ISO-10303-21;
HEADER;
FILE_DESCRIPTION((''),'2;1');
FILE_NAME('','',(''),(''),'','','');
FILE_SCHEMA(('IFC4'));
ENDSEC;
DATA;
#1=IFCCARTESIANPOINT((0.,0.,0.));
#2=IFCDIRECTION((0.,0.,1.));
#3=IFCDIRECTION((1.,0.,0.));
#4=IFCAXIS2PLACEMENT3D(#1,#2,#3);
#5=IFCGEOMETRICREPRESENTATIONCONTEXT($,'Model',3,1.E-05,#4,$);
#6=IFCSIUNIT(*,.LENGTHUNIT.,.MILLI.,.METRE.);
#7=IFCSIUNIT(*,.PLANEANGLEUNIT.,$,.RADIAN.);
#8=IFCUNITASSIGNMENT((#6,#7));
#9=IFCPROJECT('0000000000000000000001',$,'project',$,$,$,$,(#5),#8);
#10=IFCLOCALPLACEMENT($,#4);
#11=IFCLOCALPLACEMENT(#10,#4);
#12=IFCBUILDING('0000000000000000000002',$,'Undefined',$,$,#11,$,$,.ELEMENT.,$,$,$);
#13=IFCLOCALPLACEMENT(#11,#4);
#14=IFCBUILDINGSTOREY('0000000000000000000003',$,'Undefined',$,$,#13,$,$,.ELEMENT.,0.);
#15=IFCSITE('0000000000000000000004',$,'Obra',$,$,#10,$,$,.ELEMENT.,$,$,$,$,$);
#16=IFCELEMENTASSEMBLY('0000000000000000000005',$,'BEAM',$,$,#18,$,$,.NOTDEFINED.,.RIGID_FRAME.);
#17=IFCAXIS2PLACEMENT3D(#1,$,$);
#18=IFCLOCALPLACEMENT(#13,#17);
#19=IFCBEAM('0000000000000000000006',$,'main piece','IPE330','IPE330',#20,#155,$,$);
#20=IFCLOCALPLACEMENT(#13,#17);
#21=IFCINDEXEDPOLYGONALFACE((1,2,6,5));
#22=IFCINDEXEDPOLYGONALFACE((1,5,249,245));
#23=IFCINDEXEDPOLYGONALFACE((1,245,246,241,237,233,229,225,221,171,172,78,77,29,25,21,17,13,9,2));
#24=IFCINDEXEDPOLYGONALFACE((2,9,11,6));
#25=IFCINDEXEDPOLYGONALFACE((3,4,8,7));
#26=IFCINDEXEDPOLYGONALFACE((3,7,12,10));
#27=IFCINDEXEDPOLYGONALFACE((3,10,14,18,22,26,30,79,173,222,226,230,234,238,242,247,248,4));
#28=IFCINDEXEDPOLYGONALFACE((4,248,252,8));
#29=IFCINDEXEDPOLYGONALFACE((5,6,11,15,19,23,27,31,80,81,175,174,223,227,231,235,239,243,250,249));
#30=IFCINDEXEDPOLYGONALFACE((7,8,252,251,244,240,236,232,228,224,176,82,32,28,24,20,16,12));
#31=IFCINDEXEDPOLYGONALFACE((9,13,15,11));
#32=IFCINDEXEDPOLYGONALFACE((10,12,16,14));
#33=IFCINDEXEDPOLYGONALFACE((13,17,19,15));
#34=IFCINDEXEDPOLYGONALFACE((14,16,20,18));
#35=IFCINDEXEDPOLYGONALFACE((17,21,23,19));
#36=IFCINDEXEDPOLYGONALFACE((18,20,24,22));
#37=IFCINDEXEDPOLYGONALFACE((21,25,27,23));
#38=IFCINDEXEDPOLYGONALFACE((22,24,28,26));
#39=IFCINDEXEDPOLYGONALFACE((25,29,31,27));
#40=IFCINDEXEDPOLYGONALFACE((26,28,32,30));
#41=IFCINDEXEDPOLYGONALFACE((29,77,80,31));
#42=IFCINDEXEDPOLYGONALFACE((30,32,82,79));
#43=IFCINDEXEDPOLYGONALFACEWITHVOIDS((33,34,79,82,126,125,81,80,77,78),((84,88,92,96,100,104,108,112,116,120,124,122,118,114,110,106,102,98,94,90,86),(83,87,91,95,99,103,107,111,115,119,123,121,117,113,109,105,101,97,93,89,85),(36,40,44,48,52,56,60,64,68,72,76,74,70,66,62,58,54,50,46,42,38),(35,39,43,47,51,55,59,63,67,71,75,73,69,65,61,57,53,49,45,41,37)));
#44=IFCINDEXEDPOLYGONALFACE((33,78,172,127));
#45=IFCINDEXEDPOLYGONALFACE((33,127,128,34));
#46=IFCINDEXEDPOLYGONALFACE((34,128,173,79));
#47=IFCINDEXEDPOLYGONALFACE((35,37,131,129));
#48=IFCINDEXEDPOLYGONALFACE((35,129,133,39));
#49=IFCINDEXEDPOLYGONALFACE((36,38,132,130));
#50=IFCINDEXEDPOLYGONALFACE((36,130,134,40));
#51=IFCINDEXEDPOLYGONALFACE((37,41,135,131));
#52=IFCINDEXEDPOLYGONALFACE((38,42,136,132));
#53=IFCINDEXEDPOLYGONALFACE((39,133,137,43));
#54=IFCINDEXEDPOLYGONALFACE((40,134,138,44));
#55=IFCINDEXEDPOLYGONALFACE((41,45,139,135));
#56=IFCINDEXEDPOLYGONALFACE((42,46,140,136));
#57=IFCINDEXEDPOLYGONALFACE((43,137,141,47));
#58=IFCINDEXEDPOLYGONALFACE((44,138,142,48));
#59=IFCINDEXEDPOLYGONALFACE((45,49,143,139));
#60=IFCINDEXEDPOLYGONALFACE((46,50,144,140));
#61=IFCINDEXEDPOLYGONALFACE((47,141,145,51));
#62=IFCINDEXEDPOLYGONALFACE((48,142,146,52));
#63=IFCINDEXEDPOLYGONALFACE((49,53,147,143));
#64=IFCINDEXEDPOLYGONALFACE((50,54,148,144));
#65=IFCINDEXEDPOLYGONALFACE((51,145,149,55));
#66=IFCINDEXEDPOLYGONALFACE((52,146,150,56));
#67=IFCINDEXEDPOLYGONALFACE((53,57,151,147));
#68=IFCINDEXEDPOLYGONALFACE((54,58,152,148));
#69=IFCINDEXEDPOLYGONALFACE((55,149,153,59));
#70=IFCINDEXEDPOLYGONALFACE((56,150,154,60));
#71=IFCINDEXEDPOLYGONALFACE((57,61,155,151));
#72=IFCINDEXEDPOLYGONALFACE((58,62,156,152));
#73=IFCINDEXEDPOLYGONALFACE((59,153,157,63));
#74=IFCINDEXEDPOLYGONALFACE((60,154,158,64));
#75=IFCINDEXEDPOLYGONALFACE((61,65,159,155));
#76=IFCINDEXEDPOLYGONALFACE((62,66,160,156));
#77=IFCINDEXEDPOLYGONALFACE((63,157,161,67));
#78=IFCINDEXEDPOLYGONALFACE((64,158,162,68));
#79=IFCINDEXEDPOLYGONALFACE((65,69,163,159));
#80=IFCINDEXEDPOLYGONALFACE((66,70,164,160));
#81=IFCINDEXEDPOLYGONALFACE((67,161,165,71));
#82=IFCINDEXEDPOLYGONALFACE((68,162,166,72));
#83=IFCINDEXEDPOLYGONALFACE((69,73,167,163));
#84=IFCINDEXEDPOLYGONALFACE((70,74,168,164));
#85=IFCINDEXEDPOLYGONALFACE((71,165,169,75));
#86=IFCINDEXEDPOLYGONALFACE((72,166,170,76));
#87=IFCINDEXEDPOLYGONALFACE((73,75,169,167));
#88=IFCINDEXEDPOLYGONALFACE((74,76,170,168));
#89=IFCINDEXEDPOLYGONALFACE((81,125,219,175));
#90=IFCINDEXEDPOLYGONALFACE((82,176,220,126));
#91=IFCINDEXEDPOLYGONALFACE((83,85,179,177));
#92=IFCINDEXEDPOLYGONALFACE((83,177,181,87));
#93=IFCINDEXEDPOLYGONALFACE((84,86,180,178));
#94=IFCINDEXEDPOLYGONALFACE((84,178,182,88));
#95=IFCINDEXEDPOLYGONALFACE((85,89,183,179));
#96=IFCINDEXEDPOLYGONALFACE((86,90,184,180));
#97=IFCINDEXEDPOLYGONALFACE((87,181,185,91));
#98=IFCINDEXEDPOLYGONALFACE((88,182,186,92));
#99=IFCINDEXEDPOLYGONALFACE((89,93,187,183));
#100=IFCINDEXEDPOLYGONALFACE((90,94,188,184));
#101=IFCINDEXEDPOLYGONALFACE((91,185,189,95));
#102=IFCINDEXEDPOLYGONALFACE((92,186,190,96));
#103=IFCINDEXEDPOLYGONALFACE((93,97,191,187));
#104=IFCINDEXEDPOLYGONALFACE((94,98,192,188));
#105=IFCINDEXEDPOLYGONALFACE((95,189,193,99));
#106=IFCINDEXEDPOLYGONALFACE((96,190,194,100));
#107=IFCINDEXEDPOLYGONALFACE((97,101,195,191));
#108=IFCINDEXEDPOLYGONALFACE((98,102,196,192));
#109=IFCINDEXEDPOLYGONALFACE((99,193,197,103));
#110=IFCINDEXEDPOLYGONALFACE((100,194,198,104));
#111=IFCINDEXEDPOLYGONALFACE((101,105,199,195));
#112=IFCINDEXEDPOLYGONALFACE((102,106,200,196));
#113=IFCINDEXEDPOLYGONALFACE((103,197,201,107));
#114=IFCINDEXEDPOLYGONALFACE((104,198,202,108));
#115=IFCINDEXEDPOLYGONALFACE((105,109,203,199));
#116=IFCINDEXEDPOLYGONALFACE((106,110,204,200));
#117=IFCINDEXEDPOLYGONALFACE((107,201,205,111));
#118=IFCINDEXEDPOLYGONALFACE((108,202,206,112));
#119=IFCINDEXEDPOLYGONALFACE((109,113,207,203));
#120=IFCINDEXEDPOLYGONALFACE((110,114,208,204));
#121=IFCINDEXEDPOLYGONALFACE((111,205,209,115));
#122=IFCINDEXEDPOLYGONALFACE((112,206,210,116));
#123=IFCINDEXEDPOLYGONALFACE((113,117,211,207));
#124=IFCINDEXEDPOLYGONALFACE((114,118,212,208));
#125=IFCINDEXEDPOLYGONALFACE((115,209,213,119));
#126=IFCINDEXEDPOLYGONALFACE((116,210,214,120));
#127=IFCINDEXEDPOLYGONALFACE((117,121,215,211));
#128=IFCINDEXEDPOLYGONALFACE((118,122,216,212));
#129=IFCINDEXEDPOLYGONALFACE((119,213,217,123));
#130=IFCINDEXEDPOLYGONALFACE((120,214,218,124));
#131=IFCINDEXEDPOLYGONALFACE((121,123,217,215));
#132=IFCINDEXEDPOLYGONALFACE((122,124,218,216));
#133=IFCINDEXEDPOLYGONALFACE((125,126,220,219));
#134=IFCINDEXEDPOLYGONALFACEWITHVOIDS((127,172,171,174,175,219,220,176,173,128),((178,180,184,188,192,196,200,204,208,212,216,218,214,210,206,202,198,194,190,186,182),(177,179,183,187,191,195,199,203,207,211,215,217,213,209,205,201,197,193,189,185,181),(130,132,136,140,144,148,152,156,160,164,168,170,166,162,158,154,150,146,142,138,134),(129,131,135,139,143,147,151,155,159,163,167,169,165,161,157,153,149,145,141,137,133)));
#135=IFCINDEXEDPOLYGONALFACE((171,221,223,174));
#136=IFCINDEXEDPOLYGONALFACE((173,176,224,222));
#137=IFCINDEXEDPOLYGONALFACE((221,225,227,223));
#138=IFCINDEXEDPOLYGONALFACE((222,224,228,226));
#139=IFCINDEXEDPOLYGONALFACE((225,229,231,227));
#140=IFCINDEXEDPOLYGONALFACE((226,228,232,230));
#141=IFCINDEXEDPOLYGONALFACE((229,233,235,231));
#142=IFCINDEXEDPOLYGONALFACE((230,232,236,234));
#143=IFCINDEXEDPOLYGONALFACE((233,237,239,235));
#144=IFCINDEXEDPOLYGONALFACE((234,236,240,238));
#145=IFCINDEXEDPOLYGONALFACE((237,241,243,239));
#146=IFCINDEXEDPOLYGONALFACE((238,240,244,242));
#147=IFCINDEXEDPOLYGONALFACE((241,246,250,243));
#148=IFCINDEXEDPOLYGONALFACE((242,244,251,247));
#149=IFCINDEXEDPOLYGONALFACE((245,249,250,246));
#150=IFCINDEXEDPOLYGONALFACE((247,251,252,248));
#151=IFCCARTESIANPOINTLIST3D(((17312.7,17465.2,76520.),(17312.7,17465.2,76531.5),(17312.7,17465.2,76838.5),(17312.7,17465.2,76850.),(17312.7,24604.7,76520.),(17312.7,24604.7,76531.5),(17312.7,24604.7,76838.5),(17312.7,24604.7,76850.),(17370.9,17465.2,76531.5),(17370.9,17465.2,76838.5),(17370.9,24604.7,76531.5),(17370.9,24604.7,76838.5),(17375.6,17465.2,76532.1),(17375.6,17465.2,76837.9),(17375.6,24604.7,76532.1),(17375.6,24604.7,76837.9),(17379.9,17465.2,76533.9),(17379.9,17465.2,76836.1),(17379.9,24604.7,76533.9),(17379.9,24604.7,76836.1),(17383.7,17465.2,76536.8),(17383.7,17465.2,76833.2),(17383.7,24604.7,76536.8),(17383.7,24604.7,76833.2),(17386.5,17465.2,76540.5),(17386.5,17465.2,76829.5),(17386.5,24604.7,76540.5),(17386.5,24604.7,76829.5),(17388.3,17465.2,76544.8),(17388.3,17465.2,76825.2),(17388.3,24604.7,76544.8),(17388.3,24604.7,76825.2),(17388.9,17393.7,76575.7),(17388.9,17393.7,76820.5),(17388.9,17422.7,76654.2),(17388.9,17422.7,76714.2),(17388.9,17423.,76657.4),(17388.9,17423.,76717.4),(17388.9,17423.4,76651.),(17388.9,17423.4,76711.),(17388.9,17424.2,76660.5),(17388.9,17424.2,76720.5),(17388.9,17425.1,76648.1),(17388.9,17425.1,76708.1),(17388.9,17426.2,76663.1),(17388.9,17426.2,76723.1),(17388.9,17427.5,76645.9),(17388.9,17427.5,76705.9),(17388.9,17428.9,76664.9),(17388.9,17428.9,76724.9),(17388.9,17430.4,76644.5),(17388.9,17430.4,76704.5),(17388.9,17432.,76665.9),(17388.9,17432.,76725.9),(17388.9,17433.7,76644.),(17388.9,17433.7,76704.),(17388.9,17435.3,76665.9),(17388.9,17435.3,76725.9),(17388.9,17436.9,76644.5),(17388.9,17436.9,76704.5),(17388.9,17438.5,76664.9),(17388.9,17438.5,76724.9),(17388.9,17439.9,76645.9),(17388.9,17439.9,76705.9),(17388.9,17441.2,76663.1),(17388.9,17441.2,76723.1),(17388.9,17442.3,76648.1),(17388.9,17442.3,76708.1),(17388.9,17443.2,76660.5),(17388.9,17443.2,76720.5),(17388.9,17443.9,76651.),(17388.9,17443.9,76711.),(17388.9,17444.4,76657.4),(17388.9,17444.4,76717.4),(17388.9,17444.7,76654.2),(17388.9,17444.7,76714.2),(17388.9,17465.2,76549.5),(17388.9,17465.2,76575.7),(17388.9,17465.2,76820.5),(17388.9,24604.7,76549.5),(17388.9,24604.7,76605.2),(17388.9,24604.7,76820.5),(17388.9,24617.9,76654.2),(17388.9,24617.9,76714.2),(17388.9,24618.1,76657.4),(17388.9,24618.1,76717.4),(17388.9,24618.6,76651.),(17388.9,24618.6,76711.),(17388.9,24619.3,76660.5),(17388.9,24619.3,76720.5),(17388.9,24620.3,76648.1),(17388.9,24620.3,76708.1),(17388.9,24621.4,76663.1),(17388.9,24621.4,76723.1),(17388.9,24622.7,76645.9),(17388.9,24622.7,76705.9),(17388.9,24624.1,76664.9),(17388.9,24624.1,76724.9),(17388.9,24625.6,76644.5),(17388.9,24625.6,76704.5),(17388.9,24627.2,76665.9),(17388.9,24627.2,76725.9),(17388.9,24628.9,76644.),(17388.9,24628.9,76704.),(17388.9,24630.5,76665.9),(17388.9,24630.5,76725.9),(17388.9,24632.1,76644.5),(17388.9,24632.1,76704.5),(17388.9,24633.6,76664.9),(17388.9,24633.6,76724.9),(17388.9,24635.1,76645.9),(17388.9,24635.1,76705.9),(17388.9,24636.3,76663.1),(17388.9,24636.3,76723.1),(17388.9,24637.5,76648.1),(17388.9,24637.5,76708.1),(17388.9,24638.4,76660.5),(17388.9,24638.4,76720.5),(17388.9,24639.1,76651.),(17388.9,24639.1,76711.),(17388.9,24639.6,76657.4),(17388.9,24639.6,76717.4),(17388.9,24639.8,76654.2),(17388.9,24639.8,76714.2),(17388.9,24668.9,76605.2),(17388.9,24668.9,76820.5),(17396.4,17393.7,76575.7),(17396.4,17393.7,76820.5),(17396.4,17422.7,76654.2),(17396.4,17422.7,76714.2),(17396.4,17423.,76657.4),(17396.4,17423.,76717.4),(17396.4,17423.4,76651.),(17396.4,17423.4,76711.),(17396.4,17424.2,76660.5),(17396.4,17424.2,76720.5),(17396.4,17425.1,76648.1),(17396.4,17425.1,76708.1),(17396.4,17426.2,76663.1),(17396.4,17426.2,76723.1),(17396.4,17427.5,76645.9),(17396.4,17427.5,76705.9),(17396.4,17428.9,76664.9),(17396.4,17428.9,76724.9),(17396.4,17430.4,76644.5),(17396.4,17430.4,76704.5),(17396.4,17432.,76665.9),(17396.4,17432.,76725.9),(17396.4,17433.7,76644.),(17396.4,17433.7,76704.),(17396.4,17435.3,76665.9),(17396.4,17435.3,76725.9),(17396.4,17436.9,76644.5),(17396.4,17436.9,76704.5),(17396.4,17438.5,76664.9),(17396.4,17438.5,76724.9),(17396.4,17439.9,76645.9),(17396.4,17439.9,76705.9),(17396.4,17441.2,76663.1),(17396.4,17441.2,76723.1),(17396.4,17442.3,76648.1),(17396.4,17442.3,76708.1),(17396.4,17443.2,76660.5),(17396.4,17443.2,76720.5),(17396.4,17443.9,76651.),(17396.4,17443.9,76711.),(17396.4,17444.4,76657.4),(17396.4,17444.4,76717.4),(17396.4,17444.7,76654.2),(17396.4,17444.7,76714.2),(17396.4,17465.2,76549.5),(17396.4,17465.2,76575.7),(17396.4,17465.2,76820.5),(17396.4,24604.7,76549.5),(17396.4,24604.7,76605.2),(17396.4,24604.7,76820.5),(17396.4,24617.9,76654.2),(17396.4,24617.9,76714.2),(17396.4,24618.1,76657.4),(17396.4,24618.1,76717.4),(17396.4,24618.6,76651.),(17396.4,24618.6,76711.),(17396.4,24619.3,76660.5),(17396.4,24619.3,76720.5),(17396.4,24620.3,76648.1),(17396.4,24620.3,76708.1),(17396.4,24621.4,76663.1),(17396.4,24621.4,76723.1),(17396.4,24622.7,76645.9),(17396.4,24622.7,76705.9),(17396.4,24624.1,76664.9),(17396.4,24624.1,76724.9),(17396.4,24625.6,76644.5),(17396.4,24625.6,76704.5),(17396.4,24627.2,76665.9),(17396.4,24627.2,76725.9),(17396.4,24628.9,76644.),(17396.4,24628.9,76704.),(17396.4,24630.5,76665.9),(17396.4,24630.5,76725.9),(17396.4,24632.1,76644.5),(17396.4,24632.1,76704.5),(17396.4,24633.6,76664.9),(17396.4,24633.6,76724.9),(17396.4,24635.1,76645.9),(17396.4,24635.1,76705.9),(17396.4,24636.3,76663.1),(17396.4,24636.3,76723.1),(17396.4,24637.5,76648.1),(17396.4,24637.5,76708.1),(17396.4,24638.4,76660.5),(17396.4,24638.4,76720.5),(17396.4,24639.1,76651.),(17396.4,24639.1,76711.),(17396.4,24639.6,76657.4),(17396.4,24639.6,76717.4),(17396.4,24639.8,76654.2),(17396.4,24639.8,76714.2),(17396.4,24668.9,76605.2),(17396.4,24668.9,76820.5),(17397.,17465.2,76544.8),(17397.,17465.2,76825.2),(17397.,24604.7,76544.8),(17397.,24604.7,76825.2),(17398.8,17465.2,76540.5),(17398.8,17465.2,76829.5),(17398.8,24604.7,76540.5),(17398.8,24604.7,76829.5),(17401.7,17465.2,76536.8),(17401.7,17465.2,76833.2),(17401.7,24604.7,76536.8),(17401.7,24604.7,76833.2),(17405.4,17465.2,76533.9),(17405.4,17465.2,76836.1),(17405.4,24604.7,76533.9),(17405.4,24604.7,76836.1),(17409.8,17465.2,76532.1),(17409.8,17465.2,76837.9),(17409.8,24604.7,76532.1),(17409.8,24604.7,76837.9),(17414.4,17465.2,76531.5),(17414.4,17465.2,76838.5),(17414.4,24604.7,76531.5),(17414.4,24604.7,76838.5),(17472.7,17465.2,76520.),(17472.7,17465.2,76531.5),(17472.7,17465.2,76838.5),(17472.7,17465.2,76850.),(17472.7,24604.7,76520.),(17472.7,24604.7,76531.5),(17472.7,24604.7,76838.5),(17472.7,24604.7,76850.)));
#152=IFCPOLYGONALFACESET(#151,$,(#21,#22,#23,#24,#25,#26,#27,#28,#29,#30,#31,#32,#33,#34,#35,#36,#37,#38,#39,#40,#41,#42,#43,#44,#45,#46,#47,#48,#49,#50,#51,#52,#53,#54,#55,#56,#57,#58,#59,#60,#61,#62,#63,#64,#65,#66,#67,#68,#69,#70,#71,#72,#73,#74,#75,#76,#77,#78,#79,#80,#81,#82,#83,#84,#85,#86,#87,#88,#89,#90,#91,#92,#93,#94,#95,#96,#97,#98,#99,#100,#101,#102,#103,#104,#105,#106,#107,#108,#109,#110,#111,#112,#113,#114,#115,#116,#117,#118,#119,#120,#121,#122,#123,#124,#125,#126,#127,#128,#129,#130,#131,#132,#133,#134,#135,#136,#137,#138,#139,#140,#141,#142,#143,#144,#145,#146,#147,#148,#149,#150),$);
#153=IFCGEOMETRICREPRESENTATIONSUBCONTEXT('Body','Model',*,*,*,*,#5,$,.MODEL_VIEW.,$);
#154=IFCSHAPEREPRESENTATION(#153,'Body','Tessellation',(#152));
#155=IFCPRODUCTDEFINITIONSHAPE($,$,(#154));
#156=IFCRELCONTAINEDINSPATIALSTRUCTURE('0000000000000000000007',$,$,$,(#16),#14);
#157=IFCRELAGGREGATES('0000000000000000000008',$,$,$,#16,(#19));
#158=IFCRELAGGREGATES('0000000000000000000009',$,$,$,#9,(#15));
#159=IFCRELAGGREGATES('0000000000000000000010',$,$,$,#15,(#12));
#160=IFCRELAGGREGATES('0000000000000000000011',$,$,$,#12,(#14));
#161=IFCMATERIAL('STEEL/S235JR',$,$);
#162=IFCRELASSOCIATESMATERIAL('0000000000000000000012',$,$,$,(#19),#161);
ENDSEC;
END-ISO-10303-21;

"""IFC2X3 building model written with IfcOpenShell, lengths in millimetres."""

from ifc_helpers import new_model, si_unit, frame, origin_with_axes, origin_2d_with_axis, place, context, subcontext, project, spatial, rectangle, circle, i_section, extrude, clip, halfspace, source, transform, mapped, material, element, aggregate, save


model = new_model("IFC2X3")

# Units and contexts
model_context = context("Model", 3, precision=1e-05, world=origin_with_axes())
body_context = subcontext(model_context, "Body", "Model", "MODEL_VIEW")
ifc_project = project(units=[si_unit("LENGTHUNIT", "METRE", prefix="MILLI"), si_unit("PLANEANGLEUNIT", "RADIAN")], contexts=[model_context])

# Site, building, storey
site_placement = place(None, origin_with_axes())
site = spatial("IfcSite", under=ifc_project, at=site_placement, Name="Obra", CompositionType="ELEMENT")
building_placement = place(site_placement, origin_with_axes())
building = spatial("IfcBuilding", under=site, at=building_placement, Name="Undefined", CompositionType="ELEMENT")
storey_placement = place(building_placement, origin_with_axes())
storey = spatial("IfcBuildingStorey", under=building, at=storey_placement, Name="Undefined", CompositionType="ELEMENT", Elevation=0.0)

# Shared definitions
ifc_material = material(Name="STEEL/S235JR")

# Element assembly, beam, openings
assembly_1_placement = place(storey_placement, origin_with_axes())
assembly_1 = element("IfcElementAssembly", 1, at=assembly_1_placement, inside=storey, Name="BEAM", AssemblyPlace="NOTDEFINED", PredefinedType="RIGID_FRAME")
beam_1_placement = place(assembly_1_placement, frame((17392.7, 17475.1, 76685.0), z_axis=(0.0, 0.0, 1.0), x_axis=(0.0, 1.0, 0.0)))
beam_1 = element("IfcBeam", 2, at=beam_1_placement, material=ifc_material, Name="main piece", Description="IPE330", ObjectType="IPE330", context=body_context, shape_type="Clipping", body=[
    clip(clip(extrude(i_section(OverallWidth=160.0, OverallDepth=330.0, WebThickness=7.5, FlangeThickness=11.5, FilletRadius=18.0, at=origin_2d_with_axis()), frame((7193.7, 0.0, 0.0), z_axis=(-1.0, 0.0, 0.0), x_axis=(0.0, -1.0, 0.0)), (0.0, 0.0, 1.0), 7275.2), halfspace(frame((7193.7, 0.0, -265.0), z_axis=(-1.0, -0.000002, 0.0), x_axis=(-0.000002, 1.0, 0.0)), True)), halfspace(frame((-81.4, 0.0, -265.0), z_axis=(1.0, 0.0, 0.0), x_axis=(0.0, -1.0, 0.0)), True)),
])
opening_1_placement = place(assembly_1_placement, frame((17392.7, 17475.1, 76685.0), z_axis=(0.0, 0.0, 1.0), x_axis=(0.0, 1.0, 0.0)))
element("IfcOpeningElement", 3, at=opening_1_placement, cuts=beam_1, ObjectType="Recess", context=body_context, shape_type="SweptSolid", body=[
    extrude(rectangle(XDim=56.7, YDim=83.5, at=origin_2d_with_axis()), frame((-51.7, -81.0, -137.7), z_axis=(0.0, 1.0, 0.0), x_axis=(0.0, 0.0, -1.0)), (0.0, 0.0, 1.0), 162.0),
])
opening_2_placement = place(assembly_1_placement, frame((17392.7, 17475.1, 76685.0), z_axis=(0.0, 0.0, 1.0), x_axis=(0.0, 1.0, 0.0)))
element("IfcOpeningElement", 4, at=opening_2_placement, cuts=beam_1, ObjectType="Recess", context=body_context, shape_type="SweptSolid", body=[
    extrude(rectangle(XDim=30.5, YDim=83.5, at=origin_2d_with_axis()), frame((-51.7, -81.0, 150.8), z_axis=(0.0, 1.0, 0.0), x_axis=(0.0, 0.0, -1.0)), (0.0, 0.0, 1.0), 162.0),
])
opening_3_placement = place(assembly_1_placement, frame((17392.7, 17475.1, 76685.0), z_axis=(0.0, 0.0, 1.0), x_axis=(0.0, 1.0, 0.0)))
element("IfcOpeningElement", 5, at=opening_3_placement, cuts=beam_1, ObjectType="Recess", context=body_context, shape_type="SweptSolid", body=[
    extrude(rectangle(XDim=76.2, YDim=86.2, at=origin_2d_with_axis()), frame((7167.6, 81.0, -122.9), z_axis=(0.000002, -1.0, 0.0), x_axis=(1.0, 0.000002, 0.0)), (0.0, 0.0, 1.0), 162.0),
])
opening_4_placement = place(assembly_1_placement, frame((17392.7, 17475.1, 76685.0), z_axis=(0.0, 0.0, 1.0), x_axis=(0.0, 1.0, 0.0)))
element("IfcOpeningElement", 6, at=opening_4_placement, cuts=beam_1, ObjectType="Recess", context=body_context, shape_type="SweptSolid", body=[
    extrude(rectangle(XDim=30.5, YDim=76.2, at=origin_2d_with_axis()), frame((7167.6, 81.0, 150.8), z_axis=(0.000002, -1.0, 0.0), x_axis=(0.0, 0.0, -1.0)), (0.0, 0.0, 1.0), 162.0),
])
shared_shape_1 = source(origin_with_axes(), body_context, "Body", "SweptSolid", [
    extrude(circle(Radius=11.0, at=origin_2d_with_axis()), frame((0.0, -3.9, 0.0), z_axis=(0.0, 1.0, 0.0), x_axis=(1.0, 0.0, 0.0)), (0.0, 0.0, 1.0), 7.7),
])
opening_5_placement = place(assembly_1_placement, frame((17392.7, 17393.7, 76850.0), z_axis=(0.0, 1.0, 0.0), x_axis=(0.0, 0.0, -1.0)))
element("IfcOpeningElement", 7, at=opening_5_placement, cuts=beam_1, ObjectType="Opening", context=body_context, shape_type="MappedRepresentation", body=[
    mapped(shared_shape_1, transform((135.0, 0.0, 40.0))),
    mapped(shared_shape_1, transform((195.0, 0.0, 40.0))),
])
opening_6_placement = place(assembly_1_placement, frame((17392.7, 24668.9, 76850.0), z_axis=(0.000002, -1.0, 0.0), x_axis=(0.0, 0.0, -1.0)))
element("IfcOpeningElement", 8, at=opening_6_placement, cuts=beam_1, ObjectType="Opening", context=body_context, shape_type="MappedRepresentation", body=[
    mapped(shared_shape_1, transform((135.0, 0.0, 40.0))),
    mapped(shared_shape_1, transform((195.0, 0.0, 40.0))),
])
aggregate(assembly_1, [beam_1])

save(model, "model.ifc")
